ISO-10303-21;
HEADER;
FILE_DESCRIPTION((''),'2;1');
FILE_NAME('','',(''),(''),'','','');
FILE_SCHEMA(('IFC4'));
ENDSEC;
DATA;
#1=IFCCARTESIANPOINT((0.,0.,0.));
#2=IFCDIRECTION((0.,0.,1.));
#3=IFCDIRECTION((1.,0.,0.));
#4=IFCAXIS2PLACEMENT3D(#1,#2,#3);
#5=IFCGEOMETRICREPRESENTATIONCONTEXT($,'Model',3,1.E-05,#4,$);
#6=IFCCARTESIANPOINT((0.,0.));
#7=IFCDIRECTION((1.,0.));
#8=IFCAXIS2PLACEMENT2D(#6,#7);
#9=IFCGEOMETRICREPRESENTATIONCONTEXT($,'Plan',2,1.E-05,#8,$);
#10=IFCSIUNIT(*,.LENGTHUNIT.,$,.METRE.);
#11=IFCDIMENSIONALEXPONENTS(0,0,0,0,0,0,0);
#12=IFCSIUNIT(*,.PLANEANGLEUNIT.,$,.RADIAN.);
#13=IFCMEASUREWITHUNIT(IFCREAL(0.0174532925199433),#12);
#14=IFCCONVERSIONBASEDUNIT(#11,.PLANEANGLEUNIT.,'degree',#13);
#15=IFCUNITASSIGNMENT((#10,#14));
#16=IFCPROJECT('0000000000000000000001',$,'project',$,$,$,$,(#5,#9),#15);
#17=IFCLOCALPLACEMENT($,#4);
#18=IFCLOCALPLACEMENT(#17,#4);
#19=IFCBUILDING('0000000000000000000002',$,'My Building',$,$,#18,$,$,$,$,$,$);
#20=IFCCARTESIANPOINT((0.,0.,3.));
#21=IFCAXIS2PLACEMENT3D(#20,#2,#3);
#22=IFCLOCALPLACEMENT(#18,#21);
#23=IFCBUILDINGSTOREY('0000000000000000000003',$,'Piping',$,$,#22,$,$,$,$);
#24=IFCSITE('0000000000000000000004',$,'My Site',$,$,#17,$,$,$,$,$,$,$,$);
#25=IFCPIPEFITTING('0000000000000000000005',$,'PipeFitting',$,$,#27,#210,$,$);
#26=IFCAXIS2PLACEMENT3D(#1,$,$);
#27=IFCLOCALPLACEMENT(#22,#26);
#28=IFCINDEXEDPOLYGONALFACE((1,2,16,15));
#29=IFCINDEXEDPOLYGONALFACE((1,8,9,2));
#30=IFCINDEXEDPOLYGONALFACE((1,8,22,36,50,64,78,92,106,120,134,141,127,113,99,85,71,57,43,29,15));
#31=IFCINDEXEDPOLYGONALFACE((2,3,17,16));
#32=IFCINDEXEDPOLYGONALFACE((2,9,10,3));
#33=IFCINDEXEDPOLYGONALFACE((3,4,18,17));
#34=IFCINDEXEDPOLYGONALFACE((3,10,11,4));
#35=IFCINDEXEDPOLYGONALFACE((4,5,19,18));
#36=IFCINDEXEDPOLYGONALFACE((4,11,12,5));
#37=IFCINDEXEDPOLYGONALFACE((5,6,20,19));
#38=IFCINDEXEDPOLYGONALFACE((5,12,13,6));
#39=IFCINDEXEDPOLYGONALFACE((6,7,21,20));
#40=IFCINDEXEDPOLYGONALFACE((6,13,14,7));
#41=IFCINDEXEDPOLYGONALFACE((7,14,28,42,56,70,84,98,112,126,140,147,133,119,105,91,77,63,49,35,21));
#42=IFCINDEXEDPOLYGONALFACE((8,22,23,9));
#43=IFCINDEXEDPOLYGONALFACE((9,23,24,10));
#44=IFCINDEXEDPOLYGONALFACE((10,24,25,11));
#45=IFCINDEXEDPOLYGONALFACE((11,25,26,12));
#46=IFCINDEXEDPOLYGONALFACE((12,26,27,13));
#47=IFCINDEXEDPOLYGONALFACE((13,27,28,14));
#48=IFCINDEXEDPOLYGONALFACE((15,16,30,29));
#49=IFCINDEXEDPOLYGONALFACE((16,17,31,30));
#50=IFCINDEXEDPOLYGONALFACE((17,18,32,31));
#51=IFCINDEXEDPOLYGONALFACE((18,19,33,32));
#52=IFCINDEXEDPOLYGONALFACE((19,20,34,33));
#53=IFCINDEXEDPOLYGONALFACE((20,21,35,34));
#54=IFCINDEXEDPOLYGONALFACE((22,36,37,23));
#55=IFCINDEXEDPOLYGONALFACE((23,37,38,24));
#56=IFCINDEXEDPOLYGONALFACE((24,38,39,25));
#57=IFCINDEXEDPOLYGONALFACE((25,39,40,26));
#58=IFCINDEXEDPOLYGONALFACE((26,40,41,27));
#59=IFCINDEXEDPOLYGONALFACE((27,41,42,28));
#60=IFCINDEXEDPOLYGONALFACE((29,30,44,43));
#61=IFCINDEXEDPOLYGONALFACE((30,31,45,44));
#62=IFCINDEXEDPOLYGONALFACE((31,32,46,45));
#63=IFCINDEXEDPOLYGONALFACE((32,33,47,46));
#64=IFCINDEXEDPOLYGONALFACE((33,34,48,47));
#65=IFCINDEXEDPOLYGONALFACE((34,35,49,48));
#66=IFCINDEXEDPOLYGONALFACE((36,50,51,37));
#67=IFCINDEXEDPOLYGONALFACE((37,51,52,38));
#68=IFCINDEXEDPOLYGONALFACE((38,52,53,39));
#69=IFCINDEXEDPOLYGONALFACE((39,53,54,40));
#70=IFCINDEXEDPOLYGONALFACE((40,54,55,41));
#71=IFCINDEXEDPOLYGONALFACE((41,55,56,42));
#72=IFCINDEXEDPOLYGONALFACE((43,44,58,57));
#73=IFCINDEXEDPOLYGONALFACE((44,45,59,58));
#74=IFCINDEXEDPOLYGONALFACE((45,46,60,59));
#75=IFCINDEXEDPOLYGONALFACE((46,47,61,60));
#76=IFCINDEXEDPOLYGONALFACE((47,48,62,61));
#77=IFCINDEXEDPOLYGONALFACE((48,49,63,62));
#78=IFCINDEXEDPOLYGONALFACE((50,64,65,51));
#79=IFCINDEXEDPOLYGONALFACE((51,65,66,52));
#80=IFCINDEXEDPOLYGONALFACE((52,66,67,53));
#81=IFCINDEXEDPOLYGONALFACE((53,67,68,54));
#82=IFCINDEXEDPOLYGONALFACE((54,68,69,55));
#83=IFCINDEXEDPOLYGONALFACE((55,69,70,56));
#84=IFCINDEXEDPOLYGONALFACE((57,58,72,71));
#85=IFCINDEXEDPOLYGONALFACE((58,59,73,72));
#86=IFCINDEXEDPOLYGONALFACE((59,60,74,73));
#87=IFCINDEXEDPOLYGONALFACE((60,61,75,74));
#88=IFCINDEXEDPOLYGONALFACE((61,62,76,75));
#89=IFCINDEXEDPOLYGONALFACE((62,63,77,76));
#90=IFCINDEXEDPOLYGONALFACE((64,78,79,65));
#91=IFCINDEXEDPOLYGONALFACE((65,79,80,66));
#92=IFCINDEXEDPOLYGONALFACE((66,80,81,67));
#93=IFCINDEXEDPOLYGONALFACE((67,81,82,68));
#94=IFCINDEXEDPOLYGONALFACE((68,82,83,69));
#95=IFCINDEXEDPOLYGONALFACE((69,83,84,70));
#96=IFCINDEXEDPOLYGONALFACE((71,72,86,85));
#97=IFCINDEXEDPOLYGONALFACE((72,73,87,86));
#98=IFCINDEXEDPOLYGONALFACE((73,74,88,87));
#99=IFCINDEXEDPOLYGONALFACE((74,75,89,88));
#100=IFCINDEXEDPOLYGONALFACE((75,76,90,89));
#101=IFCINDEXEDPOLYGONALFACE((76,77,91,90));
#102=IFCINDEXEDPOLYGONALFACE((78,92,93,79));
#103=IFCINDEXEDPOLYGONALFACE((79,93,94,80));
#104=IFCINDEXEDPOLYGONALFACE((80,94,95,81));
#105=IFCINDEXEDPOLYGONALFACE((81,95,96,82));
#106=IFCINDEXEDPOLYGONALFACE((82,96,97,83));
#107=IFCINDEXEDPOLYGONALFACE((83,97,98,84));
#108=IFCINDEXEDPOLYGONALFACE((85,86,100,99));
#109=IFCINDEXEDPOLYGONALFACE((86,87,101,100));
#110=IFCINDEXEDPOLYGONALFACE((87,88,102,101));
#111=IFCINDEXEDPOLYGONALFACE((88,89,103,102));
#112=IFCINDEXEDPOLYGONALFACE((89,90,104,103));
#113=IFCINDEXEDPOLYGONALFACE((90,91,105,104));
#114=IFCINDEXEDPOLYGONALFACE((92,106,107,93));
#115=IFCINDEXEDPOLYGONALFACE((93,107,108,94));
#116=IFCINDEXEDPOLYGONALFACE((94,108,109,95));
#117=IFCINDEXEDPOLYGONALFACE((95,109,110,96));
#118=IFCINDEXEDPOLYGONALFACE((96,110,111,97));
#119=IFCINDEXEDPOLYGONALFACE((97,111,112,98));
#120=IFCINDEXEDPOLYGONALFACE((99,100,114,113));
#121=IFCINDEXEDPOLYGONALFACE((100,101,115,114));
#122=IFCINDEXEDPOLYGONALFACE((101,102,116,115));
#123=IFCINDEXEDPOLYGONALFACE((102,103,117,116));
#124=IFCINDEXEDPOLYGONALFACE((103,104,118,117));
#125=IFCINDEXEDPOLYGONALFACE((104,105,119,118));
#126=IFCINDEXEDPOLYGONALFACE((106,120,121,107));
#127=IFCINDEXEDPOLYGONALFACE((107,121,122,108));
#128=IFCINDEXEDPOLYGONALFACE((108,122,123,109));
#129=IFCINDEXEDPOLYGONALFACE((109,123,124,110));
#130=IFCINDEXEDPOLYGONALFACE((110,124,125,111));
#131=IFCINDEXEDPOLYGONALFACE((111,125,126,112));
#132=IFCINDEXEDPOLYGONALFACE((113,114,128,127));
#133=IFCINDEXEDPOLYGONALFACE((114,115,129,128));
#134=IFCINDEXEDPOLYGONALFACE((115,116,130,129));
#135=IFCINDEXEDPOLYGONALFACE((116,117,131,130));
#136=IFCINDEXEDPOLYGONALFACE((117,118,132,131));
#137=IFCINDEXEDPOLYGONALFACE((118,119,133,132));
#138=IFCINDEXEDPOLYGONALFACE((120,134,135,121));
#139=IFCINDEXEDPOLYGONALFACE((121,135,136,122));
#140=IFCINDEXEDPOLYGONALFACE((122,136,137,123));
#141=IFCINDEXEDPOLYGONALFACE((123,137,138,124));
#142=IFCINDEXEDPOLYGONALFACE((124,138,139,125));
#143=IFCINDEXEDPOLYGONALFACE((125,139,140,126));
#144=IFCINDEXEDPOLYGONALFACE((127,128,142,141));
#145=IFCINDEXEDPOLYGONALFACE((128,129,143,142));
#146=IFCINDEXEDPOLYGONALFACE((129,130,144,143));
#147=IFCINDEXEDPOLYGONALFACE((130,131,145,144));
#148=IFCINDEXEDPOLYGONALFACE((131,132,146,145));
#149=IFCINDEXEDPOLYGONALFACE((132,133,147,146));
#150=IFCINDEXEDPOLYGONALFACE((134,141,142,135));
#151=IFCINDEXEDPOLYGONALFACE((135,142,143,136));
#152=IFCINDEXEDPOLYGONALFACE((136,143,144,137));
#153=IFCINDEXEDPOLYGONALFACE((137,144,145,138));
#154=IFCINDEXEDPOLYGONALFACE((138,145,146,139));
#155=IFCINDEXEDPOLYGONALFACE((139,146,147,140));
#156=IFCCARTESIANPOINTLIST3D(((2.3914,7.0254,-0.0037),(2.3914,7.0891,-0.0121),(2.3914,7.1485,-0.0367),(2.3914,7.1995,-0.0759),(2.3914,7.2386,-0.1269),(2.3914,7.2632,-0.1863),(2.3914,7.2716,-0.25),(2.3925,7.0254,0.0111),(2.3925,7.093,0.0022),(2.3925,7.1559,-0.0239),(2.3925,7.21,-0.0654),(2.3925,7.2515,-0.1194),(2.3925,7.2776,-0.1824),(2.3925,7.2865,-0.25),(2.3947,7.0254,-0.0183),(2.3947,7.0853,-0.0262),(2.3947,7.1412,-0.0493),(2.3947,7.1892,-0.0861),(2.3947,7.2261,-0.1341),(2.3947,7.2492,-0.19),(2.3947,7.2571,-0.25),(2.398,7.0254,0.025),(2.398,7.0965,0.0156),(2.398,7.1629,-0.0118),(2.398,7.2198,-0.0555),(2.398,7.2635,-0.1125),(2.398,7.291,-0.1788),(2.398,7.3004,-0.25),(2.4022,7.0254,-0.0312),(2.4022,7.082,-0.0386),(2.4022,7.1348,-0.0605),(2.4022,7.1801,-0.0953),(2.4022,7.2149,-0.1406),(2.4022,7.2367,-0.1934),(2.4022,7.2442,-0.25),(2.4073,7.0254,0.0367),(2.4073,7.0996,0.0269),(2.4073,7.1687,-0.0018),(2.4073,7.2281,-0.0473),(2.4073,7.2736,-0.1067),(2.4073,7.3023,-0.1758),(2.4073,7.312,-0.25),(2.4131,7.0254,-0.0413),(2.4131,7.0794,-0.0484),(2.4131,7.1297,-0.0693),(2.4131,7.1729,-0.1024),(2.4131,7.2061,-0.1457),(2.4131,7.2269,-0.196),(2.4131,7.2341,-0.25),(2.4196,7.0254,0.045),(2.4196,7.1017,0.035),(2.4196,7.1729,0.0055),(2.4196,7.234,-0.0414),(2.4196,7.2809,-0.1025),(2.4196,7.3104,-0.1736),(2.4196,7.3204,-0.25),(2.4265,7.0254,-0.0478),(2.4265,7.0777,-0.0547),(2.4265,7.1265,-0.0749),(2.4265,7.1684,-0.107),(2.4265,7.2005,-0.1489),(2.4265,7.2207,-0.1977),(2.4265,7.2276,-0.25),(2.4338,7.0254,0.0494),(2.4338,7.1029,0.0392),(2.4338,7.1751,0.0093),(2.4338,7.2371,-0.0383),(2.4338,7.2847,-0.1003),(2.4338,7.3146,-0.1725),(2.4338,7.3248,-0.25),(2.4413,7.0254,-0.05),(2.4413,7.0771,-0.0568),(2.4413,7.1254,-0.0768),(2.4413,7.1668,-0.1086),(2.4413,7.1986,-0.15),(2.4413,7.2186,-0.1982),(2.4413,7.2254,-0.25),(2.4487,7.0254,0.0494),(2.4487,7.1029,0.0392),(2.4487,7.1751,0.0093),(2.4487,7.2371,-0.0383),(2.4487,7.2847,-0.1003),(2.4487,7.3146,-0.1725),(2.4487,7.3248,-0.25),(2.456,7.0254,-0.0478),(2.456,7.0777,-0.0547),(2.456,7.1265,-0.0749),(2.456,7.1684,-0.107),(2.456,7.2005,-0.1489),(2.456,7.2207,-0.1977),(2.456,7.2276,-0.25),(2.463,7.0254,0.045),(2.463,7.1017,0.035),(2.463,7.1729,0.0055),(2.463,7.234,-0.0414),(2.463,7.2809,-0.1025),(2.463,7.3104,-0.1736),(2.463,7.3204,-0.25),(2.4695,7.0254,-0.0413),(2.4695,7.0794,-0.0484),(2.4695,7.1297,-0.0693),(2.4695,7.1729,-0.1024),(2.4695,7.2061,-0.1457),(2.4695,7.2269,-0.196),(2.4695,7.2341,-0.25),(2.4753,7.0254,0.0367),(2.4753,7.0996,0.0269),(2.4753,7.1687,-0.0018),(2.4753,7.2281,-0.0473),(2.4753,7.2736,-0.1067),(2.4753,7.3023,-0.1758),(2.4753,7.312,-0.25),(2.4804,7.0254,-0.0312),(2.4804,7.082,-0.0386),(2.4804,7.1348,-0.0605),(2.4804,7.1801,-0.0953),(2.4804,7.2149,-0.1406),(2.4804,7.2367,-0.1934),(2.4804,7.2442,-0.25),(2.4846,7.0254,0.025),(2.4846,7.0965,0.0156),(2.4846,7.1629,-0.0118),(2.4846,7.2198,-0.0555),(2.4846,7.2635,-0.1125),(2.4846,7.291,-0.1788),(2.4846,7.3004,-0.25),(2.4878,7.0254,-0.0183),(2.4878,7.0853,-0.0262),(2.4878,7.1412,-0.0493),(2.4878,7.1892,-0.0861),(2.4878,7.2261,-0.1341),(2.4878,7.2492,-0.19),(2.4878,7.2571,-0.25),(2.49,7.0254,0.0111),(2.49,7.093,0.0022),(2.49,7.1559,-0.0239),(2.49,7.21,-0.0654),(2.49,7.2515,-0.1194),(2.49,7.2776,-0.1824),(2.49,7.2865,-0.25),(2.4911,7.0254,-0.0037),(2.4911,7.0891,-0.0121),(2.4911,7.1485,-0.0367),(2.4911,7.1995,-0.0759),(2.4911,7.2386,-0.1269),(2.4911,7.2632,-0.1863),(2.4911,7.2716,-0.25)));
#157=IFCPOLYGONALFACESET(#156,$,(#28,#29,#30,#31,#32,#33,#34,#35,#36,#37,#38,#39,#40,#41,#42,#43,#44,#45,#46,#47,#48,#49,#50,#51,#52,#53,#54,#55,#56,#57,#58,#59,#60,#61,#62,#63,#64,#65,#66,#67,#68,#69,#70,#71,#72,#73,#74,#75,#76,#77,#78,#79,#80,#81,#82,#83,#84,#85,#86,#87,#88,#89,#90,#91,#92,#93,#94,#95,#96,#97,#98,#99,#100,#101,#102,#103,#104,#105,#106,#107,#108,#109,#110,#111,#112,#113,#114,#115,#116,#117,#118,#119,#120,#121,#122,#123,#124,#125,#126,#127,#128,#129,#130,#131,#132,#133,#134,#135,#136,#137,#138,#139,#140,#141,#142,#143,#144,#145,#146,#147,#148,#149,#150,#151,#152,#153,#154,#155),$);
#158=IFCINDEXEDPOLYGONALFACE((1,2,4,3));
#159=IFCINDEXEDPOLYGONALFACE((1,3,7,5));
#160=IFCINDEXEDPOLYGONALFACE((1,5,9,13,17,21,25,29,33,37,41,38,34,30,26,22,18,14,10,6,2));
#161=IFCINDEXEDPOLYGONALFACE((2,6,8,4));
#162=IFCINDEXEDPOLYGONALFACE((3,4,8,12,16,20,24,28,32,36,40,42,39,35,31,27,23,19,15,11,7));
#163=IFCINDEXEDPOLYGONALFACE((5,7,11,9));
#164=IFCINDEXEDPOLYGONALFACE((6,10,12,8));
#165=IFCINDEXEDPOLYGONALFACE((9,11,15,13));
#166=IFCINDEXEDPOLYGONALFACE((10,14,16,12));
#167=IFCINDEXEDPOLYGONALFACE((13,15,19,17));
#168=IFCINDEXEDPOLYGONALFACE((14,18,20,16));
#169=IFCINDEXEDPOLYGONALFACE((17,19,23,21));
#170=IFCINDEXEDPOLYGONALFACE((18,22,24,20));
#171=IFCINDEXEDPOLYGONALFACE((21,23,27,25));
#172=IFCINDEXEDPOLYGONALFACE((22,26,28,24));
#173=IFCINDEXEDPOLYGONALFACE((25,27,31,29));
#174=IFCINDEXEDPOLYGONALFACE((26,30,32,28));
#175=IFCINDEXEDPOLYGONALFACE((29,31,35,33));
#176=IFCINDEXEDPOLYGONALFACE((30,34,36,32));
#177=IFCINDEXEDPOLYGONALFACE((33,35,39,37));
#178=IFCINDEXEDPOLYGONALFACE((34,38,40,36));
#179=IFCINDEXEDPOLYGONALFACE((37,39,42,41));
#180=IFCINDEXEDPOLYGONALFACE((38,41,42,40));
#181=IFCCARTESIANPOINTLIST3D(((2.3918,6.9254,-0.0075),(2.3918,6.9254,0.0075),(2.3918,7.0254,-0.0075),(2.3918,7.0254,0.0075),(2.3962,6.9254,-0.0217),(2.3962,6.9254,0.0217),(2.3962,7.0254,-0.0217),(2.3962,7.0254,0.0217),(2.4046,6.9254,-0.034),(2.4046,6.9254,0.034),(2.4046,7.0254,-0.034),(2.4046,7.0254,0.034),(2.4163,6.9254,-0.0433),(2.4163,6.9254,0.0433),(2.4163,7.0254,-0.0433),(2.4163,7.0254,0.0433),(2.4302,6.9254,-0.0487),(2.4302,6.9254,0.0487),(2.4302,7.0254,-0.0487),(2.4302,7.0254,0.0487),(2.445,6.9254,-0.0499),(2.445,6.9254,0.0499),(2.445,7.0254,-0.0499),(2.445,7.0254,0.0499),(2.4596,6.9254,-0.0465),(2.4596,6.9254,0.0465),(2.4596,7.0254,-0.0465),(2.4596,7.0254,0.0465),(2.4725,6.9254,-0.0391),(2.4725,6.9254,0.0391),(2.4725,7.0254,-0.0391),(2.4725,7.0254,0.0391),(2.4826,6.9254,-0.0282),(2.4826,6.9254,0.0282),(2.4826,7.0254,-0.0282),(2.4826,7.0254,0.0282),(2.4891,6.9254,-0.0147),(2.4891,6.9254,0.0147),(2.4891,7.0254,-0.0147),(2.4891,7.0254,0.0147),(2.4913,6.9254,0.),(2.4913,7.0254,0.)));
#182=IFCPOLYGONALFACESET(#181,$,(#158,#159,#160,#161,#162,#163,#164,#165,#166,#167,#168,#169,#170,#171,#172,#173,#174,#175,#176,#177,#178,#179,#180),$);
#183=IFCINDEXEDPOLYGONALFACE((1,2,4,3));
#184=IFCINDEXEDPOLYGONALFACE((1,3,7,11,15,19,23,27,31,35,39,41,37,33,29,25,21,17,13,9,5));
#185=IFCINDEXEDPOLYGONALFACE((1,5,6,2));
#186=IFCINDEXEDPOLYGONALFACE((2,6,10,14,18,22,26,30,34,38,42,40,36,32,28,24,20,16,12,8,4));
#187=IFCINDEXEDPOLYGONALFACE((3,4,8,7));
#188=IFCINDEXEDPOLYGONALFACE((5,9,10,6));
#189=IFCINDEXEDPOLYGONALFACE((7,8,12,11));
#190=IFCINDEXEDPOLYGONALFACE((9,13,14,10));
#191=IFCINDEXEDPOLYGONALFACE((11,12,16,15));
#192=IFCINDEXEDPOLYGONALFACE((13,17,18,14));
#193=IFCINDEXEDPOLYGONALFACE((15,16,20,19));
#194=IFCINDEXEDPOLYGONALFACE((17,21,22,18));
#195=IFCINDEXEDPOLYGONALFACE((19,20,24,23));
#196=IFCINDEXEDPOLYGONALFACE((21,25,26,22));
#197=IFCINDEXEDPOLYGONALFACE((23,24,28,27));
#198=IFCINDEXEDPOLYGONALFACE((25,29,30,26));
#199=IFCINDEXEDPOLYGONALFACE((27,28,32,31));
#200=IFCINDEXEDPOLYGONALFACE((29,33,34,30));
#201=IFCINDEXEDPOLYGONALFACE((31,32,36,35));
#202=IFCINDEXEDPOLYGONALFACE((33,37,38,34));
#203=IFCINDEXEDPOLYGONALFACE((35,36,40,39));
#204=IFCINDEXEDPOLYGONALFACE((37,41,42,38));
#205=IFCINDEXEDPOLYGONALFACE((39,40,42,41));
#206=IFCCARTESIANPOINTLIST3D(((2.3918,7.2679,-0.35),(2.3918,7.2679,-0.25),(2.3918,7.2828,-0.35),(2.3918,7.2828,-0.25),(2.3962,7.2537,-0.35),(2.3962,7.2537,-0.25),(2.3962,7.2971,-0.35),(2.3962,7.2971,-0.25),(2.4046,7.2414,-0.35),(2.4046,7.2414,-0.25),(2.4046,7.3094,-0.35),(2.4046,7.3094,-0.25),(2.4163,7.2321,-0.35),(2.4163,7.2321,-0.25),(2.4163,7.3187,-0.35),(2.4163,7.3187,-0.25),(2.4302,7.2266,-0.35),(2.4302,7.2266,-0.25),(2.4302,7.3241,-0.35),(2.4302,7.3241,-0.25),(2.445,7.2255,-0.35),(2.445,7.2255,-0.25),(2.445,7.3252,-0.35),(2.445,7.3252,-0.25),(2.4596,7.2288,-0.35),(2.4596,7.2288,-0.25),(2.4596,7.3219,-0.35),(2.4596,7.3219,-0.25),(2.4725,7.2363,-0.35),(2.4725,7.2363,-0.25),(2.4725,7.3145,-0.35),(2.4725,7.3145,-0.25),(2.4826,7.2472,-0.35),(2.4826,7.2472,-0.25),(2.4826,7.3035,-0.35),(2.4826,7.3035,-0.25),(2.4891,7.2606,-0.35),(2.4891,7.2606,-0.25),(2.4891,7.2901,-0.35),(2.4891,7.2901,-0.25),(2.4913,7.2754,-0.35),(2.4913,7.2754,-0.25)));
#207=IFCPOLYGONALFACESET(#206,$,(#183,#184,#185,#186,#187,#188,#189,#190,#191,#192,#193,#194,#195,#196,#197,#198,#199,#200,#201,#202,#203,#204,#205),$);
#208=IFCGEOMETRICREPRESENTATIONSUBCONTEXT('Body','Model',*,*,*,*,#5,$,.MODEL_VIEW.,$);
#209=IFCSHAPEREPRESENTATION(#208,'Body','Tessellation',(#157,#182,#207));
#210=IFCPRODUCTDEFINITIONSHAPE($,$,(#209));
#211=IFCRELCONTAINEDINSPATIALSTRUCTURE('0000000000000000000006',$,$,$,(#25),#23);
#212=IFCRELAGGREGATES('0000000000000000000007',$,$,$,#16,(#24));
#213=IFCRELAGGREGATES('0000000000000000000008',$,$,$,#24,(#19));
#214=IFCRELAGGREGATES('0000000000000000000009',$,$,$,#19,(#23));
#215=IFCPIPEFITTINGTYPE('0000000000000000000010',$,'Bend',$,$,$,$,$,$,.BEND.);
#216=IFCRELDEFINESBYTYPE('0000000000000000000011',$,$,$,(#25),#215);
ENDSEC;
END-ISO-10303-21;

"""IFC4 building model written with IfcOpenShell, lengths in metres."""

from ifc_helpers import new_model, entity, si_unit, converted_unit, frame, origin_with_axes, origin_2d_with_axis, place, context, subcontext, project, spatial, circle, extrude, source, transform, mapped, type_object, type_shapes, element, save


model = new_model("IFC4")

# Units and contexts
model_context = context("Model", 3, precision=1e-05, world=origin_with_axes())
plan_context = context("Plan", 2, precision=1e-05, world=origin_2d_with_axis())
body_context = subcontext(model_context, "Body", "Model", "MODEL_VIEW")
ifc_project = project(units=[si_unit("LENGTHUNIT", "METRE"), converted_unit("PLANEANGLEUNIT", "degree", entity("IfcReal", 0.0174532925199433), si_unit("PLANEANGLEUNIT", "RADIAN"), dimensions=[0, 0, 0, 0, 0, 0, 0])], contexts=[model_context, plan_context])

# Site, building, storey
site_placement = place(None, origin_with_axes())
site = spatial("IfcSite", under=ifc_project, at=site_placement, Name="My Site")
building_placement = place(site_placement, origin_with_axes())
building = spatial("IfcBuilding", under=site, at=building_placement, Name="My Building")
storey_placement = place(building_placement, frame((0.0, 0.0, 3.0), z_axis=(0.0, 0.0, 1.0), x_axis=(1.0, 0.0, 0.0)))
storey = spatial("IfcBuildingStorey", under=building, at=storey_placement, Name="Piping")

# Pipe fitting
pipe_fitting_type = type_object("IfcPipeFittingType", Name="Bend", PredefinedType="BEND")
shared_shape = source(origin_with_axes(), body_context, "Body", "SolidModel", [
    entity("IfcSweptDiskSolid", entity("IfcIndexedPolyCurve", entity("IfcCartesianPointList3D", [[0.0, 0.0, -0.1], [0.0, -0.0732, -0.2768], [0.0, -0.25, -0.35]]), [entity("IfcArcIndex", [1, 2, 3])]), 0.05),
    extrude(circle(Radius=0.05), origin_with_axes(), (0.0, 0.0, -1.0), 0.1),
    extrude(circle(Radius=0.05), frame((0.0, -0.25, -0.35), z_axis=(0.0, -1.0, 0.0), x_axis=(1.0, 0.0, 0.0)), (0.0, 0.0, 1.0), 0.1),
])
type_shapes(pipe_fitting_type, [shared_shape])
for number, where, z_axis, x_axis, name in (
    (1, (2.4413, 6.9254, 0.0), (0.0, -1.0, 0.0), (1.0, 0.0, 0.0), "PipeFitting"),
):
    element("IfcPipeFitting", number, at=place(storey_placement, frame(where, z_axis=z_axis, x_axis=x_axis)), inside=storey, type_object=pipe_fitting_type, Name=name, context=body_context, shape_type="MappedRepresentation", body=[
        mapped(shared_shape, transform((0.0, 0.0, 0.0), x_axis=(1.0, 0.0, 0.0), y_axis=(0.0, 1.0, 0.0), z_axis=(0.0, 0.0, 1.0), scale=1.0)),
    ])

save(model, "model.ifc")
